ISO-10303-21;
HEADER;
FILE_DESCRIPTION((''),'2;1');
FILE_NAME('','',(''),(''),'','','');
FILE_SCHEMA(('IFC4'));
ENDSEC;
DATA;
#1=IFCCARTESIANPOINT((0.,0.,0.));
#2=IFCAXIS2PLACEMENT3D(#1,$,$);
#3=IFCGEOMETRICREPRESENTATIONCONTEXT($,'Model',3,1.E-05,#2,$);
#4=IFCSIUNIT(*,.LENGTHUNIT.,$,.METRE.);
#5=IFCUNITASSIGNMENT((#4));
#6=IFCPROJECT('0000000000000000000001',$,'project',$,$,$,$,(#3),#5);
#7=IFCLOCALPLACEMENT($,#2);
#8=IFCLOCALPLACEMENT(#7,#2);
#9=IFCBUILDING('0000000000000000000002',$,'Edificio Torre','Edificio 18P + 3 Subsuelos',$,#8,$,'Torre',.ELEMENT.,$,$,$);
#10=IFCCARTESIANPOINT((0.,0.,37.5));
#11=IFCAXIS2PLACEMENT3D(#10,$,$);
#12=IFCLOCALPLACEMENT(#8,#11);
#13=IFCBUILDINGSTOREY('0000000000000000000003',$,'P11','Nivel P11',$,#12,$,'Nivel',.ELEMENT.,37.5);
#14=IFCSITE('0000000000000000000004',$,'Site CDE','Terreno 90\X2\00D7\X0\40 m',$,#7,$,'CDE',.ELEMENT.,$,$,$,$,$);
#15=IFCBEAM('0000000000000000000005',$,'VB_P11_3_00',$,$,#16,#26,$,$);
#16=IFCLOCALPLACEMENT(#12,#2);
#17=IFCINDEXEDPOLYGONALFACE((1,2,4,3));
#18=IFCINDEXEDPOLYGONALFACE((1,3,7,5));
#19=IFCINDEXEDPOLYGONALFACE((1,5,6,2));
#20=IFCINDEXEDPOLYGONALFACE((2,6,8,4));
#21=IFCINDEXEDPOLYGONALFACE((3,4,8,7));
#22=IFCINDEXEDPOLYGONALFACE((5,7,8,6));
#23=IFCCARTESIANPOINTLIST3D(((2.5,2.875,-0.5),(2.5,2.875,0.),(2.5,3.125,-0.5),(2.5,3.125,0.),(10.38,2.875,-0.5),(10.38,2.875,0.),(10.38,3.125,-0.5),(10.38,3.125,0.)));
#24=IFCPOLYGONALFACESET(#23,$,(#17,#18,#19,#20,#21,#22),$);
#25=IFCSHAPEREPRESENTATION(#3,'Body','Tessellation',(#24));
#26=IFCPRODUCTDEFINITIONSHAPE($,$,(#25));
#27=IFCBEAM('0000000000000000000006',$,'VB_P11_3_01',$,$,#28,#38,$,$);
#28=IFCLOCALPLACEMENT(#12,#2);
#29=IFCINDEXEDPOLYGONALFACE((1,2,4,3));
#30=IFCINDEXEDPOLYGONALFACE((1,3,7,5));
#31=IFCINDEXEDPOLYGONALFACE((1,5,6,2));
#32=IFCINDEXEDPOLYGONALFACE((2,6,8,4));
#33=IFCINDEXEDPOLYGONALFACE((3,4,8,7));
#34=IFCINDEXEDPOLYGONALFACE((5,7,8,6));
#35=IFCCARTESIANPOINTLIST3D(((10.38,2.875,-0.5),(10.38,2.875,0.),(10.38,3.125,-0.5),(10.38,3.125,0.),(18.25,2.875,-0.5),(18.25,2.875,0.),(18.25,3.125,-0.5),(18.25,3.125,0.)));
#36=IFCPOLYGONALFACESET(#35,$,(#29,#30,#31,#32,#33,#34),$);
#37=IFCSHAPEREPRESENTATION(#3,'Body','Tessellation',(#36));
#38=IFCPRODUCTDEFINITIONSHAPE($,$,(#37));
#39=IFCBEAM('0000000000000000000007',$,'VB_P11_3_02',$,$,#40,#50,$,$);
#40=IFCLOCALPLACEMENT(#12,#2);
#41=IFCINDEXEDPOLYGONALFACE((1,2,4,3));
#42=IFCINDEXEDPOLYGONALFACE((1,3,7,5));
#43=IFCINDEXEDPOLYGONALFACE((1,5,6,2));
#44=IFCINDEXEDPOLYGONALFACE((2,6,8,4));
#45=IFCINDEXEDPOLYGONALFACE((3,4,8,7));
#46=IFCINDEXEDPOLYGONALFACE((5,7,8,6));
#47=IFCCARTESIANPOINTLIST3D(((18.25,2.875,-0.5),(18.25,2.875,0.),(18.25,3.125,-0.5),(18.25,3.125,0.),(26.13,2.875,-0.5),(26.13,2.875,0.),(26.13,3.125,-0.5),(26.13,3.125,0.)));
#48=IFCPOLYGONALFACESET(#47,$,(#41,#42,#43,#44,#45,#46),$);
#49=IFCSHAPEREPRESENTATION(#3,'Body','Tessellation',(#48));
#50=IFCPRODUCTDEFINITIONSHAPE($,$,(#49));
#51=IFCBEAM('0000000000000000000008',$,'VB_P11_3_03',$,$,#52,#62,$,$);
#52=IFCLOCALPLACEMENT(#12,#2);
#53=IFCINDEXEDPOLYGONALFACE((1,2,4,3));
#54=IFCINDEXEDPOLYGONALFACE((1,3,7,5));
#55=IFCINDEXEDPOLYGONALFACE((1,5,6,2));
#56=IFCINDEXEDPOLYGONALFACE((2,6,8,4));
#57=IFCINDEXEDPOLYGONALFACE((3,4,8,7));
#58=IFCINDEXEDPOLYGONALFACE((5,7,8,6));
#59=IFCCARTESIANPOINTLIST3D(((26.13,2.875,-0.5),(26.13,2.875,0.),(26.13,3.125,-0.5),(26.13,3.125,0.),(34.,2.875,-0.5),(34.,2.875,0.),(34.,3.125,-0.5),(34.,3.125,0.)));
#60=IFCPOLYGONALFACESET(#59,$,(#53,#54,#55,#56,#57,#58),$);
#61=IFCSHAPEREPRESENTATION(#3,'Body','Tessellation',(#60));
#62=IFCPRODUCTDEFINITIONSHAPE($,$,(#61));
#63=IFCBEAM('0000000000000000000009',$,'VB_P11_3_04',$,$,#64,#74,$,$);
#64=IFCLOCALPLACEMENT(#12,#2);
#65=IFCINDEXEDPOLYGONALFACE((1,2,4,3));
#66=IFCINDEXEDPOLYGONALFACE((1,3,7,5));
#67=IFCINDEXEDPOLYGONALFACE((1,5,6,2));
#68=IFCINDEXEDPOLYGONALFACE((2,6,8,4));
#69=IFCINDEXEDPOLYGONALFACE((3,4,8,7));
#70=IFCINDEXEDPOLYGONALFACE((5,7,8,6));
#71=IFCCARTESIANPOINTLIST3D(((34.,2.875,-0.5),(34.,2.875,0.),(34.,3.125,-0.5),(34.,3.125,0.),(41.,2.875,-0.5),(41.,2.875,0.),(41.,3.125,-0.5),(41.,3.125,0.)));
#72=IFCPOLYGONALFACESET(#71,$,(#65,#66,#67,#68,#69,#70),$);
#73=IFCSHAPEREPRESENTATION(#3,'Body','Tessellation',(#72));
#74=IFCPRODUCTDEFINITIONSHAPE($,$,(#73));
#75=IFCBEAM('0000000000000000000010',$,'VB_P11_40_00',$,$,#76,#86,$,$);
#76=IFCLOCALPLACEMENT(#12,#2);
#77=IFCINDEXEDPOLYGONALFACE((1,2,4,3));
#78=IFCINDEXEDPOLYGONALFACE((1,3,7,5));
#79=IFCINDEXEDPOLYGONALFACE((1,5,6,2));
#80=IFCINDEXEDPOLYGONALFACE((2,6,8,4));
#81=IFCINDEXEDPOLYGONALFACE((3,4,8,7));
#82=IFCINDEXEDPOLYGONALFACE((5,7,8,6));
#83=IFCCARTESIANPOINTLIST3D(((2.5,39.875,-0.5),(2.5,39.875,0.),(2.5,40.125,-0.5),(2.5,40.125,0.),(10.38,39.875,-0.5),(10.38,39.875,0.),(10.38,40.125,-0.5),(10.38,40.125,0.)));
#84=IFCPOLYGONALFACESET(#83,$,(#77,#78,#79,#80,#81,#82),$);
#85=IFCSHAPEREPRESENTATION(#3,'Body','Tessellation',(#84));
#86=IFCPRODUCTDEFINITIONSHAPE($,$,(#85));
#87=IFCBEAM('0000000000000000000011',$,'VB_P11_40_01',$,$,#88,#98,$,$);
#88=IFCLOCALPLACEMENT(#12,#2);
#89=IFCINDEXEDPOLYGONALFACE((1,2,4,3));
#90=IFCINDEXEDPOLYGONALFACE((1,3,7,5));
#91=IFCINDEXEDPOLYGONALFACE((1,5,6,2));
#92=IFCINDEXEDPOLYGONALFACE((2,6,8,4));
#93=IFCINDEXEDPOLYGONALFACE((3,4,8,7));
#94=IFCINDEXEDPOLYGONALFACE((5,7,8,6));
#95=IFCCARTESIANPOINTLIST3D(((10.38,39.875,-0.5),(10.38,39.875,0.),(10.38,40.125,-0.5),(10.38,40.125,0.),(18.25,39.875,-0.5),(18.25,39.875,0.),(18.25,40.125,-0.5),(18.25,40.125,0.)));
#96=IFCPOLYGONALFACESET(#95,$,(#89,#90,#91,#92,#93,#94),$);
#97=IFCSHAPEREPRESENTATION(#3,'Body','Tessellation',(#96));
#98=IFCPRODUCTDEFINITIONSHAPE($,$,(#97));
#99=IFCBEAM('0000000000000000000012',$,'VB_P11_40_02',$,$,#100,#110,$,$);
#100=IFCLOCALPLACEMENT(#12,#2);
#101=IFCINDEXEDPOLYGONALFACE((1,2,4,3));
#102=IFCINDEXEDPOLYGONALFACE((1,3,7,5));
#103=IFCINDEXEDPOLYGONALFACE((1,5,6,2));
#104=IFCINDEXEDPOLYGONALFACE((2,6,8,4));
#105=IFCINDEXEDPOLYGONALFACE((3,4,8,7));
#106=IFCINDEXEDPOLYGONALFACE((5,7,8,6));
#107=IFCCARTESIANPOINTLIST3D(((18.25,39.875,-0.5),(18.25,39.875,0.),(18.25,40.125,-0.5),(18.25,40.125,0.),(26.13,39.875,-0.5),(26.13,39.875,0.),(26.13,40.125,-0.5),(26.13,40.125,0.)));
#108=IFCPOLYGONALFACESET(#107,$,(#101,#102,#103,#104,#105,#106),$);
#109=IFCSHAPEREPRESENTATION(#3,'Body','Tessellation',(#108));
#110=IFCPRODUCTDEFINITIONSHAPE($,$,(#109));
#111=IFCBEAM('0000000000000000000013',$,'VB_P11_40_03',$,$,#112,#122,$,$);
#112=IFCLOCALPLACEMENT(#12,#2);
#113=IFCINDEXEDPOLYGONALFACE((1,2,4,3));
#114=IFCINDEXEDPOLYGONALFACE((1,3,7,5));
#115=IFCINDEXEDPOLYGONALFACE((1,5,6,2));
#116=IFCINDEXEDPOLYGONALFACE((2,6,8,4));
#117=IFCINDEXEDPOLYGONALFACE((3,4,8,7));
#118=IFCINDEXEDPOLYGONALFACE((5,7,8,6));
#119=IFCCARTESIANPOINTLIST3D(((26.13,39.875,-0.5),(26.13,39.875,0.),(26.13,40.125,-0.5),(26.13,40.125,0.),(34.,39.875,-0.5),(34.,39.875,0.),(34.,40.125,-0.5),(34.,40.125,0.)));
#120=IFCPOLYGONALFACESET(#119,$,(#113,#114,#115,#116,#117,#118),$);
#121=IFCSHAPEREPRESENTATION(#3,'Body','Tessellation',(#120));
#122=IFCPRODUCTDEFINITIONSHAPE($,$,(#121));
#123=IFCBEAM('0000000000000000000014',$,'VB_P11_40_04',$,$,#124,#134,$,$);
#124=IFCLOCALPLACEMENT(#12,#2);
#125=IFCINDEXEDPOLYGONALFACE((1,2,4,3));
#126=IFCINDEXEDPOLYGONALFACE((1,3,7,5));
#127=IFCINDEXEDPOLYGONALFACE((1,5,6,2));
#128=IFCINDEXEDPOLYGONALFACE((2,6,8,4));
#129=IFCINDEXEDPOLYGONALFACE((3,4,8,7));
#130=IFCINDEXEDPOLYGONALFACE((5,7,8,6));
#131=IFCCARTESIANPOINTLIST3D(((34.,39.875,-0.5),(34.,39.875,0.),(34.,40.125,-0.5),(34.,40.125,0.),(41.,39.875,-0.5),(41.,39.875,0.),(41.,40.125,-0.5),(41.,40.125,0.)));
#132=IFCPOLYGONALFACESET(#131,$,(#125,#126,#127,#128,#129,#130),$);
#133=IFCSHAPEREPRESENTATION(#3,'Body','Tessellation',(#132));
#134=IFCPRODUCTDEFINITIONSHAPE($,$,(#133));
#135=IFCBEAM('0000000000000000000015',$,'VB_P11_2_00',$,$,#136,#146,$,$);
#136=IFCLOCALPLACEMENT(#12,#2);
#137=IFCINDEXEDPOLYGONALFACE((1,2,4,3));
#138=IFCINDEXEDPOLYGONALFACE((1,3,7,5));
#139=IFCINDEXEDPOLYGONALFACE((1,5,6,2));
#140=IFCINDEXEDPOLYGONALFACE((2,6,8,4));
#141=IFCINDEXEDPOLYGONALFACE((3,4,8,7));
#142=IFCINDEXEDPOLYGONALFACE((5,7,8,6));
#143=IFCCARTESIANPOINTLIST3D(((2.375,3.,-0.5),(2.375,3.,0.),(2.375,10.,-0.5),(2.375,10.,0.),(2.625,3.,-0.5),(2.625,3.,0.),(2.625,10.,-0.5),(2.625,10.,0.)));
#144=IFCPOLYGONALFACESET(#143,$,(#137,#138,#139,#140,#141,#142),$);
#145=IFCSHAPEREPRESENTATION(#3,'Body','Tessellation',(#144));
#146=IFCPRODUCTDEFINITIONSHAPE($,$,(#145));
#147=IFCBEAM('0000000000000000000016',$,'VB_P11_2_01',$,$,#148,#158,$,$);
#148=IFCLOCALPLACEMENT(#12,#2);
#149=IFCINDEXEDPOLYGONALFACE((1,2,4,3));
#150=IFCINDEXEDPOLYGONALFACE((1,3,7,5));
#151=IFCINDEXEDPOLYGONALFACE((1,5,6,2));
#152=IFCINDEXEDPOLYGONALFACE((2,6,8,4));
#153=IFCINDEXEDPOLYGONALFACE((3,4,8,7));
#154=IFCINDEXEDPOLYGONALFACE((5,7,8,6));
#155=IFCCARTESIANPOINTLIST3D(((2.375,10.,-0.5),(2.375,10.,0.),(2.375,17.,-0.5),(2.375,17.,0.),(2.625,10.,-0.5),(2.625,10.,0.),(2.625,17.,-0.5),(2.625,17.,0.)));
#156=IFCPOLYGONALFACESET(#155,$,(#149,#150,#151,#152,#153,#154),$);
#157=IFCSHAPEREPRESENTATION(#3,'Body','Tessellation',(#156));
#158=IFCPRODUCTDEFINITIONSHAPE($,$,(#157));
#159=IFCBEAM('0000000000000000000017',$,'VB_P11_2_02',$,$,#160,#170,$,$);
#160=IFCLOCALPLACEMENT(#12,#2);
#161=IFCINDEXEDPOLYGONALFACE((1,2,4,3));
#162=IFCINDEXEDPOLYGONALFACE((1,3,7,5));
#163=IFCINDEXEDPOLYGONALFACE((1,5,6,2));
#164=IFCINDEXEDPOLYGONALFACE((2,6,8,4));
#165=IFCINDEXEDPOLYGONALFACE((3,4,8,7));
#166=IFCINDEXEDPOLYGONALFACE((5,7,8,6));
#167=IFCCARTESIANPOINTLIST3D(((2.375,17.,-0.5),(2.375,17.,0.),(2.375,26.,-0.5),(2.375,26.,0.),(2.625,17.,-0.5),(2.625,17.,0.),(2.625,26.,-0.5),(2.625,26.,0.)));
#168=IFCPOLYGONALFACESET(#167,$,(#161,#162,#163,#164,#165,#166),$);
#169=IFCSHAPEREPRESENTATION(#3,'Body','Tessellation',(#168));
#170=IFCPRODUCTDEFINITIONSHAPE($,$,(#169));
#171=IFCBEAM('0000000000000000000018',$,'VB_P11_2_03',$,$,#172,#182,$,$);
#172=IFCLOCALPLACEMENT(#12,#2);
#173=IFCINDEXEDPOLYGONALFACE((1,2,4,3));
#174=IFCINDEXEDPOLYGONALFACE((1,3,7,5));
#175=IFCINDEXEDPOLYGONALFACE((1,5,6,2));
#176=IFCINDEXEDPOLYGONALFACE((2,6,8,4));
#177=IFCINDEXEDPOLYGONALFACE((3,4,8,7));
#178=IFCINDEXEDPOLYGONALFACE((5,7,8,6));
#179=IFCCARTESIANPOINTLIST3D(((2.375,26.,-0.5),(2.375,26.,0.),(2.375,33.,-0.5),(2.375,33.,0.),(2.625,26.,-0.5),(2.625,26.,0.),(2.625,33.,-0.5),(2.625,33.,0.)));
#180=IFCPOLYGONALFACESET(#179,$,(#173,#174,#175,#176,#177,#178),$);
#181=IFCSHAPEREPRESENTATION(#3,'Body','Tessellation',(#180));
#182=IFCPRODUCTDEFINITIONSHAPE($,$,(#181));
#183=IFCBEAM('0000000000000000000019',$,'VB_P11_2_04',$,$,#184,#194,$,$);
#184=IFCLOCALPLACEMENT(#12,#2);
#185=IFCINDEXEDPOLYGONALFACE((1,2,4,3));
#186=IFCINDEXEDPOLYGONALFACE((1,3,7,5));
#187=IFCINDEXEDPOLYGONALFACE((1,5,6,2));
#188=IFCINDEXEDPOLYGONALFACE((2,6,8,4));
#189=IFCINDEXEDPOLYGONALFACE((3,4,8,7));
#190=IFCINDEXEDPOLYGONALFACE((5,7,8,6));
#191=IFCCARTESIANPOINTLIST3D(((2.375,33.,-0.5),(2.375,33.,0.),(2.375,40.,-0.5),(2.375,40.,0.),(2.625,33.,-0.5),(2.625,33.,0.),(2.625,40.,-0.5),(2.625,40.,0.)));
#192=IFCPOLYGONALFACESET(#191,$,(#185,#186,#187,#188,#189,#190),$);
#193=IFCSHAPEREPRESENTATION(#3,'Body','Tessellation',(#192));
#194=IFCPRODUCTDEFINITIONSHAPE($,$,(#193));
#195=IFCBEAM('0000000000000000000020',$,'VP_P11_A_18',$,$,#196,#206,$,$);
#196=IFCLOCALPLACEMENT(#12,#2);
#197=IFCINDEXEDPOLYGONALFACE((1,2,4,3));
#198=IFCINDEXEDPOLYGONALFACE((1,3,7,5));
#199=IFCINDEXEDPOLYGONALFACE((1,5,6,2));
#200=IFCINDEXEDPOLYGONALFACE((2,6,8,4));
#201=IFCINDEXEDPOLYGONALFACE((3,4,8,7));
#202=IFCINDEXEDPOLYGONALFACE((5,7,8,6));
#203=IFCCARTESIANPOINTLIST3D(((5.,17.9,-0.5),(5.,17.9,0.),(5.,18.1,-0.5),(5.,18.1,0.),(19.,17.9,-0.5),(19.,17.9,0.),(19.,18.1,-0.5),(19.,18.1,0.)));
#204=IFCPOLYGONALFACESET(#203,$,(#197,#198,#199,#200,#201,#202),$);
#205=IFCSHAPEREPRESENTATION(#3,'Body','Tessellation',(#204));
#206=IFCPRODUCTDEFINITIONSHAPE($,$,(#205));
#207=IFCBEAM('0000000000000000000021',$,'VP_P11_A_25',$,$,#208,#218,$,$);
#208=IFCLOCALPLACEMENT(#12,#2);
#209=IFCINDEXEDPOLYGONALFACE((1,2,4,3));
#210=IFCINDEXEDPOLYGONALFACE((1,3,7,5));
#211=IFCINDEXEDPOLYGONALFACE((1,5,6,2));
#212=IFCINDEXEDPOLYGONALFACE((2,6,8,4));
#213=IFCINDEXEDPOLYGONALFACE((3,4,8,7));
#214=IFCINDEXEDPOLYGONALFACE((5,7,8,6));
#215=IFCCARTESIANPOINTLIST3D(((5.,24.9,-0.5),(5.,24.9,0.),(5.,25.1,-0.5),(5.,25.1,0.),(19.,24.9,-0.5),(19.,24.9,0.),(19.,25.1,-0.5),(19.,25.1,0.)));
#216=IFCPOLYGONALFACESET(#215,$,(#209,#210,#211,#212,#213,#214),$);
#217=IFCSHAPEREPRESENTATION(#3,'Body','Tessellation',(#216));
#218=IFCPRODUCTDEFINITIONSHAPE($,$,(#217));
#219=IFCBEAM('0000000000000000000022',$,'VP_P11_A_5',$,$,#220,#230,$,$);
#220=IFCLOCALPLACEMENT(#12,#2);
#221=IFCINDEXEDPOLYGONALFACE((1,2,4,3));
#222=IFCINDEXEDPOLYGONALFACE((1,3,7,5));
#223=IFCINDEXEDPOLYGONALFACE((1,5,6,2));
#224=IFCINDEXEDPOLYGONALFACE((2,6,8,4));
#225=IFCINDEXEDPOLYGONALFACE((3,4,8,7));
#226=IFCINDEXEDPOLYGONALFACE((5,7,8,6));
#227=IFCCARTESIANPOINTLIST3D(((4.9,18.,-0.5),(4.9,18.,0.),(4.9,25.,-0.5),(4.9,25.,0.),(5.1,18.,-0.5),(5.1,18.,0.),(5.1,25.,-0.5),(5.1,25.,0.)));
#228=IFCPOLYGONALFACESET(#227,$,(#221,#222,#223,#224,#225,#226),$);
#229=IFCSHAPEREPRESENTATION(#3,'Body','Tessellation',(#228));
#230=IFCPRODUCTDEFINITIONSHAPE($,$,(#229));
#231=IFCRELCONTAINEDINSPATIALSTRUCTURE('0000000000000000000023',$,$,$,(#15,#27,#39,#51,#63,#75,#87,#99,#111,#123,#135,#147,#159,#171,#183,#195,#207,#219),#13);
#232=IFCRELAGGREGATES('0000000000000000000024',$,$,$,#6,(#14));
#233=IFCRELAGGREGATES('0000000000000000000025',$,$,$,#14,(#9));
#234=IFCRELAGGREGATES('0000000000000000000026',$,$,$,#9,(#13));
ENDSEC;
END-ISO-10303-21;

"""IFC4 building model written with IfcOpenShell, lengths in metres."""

from ifc_helpers import new_model, si_unit, frame, origin, origin_2d, place, context, project, spatial, rectangle, extrude, element, save


model = new_model("IFC4")

# Units and contexts
model_context = context("Model", 3, precision=1e-05, world=origin())
ifc_project = project(units=[si_unit("LENGTHUNIT", "METRE")], contexts=[model_context])

# Site, building, storey
site_placement = place(None, origin())
site = spatial("IfcSite", under=ifc_project, at=site_placement, Name="Site CDE", Description="Terreno 90×40 m", LongName="CDE", CompositionType="ELEMENT")
building_placement = place(site_placement, origin())
building = spatial("IfcBuilding", under=site, at=building_placement, Name="Edificio Torre", Description="Edificio 18P + 3 Subsuelos", LongName="Torre", CompositionType="ELEMENT")
storey_placement = place(building_placement, frame((0.0, 0.0, 37.5)))
storey = spatial("IfcBuildingStorey", under=building, at=storey_placement, Name="P11", Description="Nivel P11", LongName="Nivel", CompositionType="ELEMENT", Elevation=37.5)

# Beams
beam_1_placement = place(storey_placement, frame((6.44, 3.0, -0.5)))
element("IfcBeam", 1, at=beam_1_placement, inside=storey, Name="VB_P11_3_00", context=model_context, shape_type="SweptSolid", body=[
    extrude(rectangle(XDim=7.88, YDim=0.25, at=origin_2d()), origin(), (0.0, 0.0, 1.0), 0.5),
])
beam_2_placement = place(storey_placement, frame((14.315, 3.0, -0.5)))
element("IfcBeam", 2, at=beam_2_placement, inside=storey, Name="VB_P11_3_01", context=model_context, shape_type="SweptSolid", body=[
    extrude(rectangle(XDim=7.87, YDim=0.25, at=origin_2d()), origin(), (0.0, 0.0, 1.0), 0.5),
])
beam_3_placement = place(storey_placement, frame((22.19, 3.0, -0.5)))
element("IfcBeam", 3, at=beam_3_placement, inside=storey, Name="VB_P11_3_02", context=model_context, shape_type="SweptSolid", body=[
    extrude(rectangle(XDim=7.88, YDim=0.25, at=origin_2d()), origin(), (0.0, 0.0, 1.0), 0.5),
])
beam_4_placement = place(storey_placement, frame((30.065, 3.0, -0.5)))
element("IfcBeam", 4, at=beam_4_placement, inside=storey, Name="VB_P11_3_03", context=model_context, shape_type="SweptSolid", body=[
    extrude(rectangle(XDim=7.87, YDim=0.25, at=origin_2d()), origin(), (0.0, 0.0, 1.0), 0.5),
])
beam_5_placement = place(storey_placement, frame((37.5, 3.0, -0.5)))
element("IfcBeam", 5, at=beam_5_placement, inside=storey, Name="VB_P11_3_04", context=model_context, shape_type="SweptSolid", body=[
    extrude(rectangle(XDim=7.0, YDim=0.25, at=origin_2d()), origin(), (0.0, 0.0, 1.0), 0.5),
])
beam_6_placement = place(storey_placement, frame((6.44, 40.0, -0.5)))
element("IfcBeam", 6, at=beam_6_placement, inside=storey, Name="VB_P11_40_00", context=model_context, shape_type="SweptSolid", body=[
    extrude(rectangle(XDim=7.88, YDim=0.25, at=origin_2d()), origin(), (0.0, 0.0, 1.0), 0.5),
])
beam_7_placement = place(storey_placement, frame((14.315, 40.0, -0.5)))
element("IfcBeam", 7, at=beam_7_placement, inside=storey, Name="VB_P11_40_01", context=model_context, shape_type="SweptSolid", body=[
    extrude(rectangle(XDim=7.87, YDim=0.25, at=origin_2d()), origin(), (0.0, 0.0, 1.0), 0.5),
])
beam_8_placement = place(storey_placement, frame((22.19, 40.0, -0.5)))
element("IfcBeam", 8, at=beam_8_placement, inside=storey, Name="VB_P11_40_02", context=model_context, shape_type="SweptSolid", body=[
    extrude(rectangle(XDim=7.88, YDim=0.25, at=origin_2d()), origin(), (0.0, 0.0, 1.0), 0.5),
])
beam_9_placement = place(storey_placement, frame((30.065, 40.0, -0.5)))
element("IfcBeam", 9, at=beam_9_placement, inside=storey, Name="VB_P11_40_03", context=model_context, shape_type="SweptSolid", body=[
    extrude(rectangle(XDim=7.87, YDim=0.25, at=origin_2d()), origin(), (0.0, 0.0, 1.0), 0.5),
])
beam_10_placement = place(storey_placement, frame((37.5, 40.0, -0.5)))
element("IfcBeam", 10, at=beam_10_placement, inside=storey, Name="VB_P11_40_04", context=model_context, shape_type="SweptSolid", body=[
    extrude(rectangle(XDim=7.0, YDim=0.25, at=origin_2d()), origin(), (0.0, 0.0, 1.0), 0.5),
])
for number, where, name in (
    (11, (2.5, 6.5, -0.5), "VB_P11_2_00"),
    (12, (2.5, 13.5, -0.5), "VB_P11_2_01"),
):
    element("IfcBeam", number, at=place(storey_placement, frame(where)), inside=storey, Name=name, context=model_context, shape_type="SweptSolid", body=[
        extrude(rectangle(XDim=0.25, YDim=7.0, at=origin_2d()), origin(), (0.0, 0.0, 1.0), 0.5),
    ])
beam_11_placement = place(storey_placement, frame((2.5, 21.5, -0.5)))
element("IfcBeam", 13, at=beam_11_placement, inside=storey, Name="VB_P11_2_02", context=model_context, shape_type="SweptSolid", body=[
    extrude(rectangle(XDim=0.25, YDim=9.0, at=origin_2d()), origin(), (0.0, 0.0, 1.0), 0.5),
])
for number, where, name in (
    (14, (2.5, 29.5, -0.5), "VB_P11_2_03"),
    (15, (2.5, 36.5, -0.5), "VB_P11_2_04"),
):
    element("IfcBeam", number, at=place(storey_placement, frame(where)), inside=storey, Name=name, context=model_context, shape_type="SweptSolid", body=[
        extrude(rectangle(XDim=0.25, YDim=7.0, at=origin_2d()), origin(), (0.0, 0.0, 1.0), 0.5),
    ])
for number, where, name in (
    (16, (12.0, 18.0, -0.5), "VP_P11_A_18"),
    (17, (12.0, 25.0, -0.5), "VP_P11_A_25"),
):
    element("IfcBeam", number, at=place(storey_placement, frame(where)), inside=storey, Name=name, context=model_context, shape_type="SweptSolid", body=[
        extrude(rectangle(XDim=14.0, YDim=0.2, at=origin_2d()), origin(), (0.0, 0.0, 1.0), 0.5),
    ])
beam_12_placement = place(storey_placement, frame((5.0, 21.5, -0.5)))
element("IfcBeam", 18, at=beam_12_placement, inside=storey, Name="VP_P11_A_5", context=model_context, shape_type="SweptSolid", body=[
    extrude(rectangle(XDim=0.2, YDim=7.0, at=origin_2d()), origin(), (0.0, 0.0, 1.0), 0.5),
])

save(model, "model.ifc")
